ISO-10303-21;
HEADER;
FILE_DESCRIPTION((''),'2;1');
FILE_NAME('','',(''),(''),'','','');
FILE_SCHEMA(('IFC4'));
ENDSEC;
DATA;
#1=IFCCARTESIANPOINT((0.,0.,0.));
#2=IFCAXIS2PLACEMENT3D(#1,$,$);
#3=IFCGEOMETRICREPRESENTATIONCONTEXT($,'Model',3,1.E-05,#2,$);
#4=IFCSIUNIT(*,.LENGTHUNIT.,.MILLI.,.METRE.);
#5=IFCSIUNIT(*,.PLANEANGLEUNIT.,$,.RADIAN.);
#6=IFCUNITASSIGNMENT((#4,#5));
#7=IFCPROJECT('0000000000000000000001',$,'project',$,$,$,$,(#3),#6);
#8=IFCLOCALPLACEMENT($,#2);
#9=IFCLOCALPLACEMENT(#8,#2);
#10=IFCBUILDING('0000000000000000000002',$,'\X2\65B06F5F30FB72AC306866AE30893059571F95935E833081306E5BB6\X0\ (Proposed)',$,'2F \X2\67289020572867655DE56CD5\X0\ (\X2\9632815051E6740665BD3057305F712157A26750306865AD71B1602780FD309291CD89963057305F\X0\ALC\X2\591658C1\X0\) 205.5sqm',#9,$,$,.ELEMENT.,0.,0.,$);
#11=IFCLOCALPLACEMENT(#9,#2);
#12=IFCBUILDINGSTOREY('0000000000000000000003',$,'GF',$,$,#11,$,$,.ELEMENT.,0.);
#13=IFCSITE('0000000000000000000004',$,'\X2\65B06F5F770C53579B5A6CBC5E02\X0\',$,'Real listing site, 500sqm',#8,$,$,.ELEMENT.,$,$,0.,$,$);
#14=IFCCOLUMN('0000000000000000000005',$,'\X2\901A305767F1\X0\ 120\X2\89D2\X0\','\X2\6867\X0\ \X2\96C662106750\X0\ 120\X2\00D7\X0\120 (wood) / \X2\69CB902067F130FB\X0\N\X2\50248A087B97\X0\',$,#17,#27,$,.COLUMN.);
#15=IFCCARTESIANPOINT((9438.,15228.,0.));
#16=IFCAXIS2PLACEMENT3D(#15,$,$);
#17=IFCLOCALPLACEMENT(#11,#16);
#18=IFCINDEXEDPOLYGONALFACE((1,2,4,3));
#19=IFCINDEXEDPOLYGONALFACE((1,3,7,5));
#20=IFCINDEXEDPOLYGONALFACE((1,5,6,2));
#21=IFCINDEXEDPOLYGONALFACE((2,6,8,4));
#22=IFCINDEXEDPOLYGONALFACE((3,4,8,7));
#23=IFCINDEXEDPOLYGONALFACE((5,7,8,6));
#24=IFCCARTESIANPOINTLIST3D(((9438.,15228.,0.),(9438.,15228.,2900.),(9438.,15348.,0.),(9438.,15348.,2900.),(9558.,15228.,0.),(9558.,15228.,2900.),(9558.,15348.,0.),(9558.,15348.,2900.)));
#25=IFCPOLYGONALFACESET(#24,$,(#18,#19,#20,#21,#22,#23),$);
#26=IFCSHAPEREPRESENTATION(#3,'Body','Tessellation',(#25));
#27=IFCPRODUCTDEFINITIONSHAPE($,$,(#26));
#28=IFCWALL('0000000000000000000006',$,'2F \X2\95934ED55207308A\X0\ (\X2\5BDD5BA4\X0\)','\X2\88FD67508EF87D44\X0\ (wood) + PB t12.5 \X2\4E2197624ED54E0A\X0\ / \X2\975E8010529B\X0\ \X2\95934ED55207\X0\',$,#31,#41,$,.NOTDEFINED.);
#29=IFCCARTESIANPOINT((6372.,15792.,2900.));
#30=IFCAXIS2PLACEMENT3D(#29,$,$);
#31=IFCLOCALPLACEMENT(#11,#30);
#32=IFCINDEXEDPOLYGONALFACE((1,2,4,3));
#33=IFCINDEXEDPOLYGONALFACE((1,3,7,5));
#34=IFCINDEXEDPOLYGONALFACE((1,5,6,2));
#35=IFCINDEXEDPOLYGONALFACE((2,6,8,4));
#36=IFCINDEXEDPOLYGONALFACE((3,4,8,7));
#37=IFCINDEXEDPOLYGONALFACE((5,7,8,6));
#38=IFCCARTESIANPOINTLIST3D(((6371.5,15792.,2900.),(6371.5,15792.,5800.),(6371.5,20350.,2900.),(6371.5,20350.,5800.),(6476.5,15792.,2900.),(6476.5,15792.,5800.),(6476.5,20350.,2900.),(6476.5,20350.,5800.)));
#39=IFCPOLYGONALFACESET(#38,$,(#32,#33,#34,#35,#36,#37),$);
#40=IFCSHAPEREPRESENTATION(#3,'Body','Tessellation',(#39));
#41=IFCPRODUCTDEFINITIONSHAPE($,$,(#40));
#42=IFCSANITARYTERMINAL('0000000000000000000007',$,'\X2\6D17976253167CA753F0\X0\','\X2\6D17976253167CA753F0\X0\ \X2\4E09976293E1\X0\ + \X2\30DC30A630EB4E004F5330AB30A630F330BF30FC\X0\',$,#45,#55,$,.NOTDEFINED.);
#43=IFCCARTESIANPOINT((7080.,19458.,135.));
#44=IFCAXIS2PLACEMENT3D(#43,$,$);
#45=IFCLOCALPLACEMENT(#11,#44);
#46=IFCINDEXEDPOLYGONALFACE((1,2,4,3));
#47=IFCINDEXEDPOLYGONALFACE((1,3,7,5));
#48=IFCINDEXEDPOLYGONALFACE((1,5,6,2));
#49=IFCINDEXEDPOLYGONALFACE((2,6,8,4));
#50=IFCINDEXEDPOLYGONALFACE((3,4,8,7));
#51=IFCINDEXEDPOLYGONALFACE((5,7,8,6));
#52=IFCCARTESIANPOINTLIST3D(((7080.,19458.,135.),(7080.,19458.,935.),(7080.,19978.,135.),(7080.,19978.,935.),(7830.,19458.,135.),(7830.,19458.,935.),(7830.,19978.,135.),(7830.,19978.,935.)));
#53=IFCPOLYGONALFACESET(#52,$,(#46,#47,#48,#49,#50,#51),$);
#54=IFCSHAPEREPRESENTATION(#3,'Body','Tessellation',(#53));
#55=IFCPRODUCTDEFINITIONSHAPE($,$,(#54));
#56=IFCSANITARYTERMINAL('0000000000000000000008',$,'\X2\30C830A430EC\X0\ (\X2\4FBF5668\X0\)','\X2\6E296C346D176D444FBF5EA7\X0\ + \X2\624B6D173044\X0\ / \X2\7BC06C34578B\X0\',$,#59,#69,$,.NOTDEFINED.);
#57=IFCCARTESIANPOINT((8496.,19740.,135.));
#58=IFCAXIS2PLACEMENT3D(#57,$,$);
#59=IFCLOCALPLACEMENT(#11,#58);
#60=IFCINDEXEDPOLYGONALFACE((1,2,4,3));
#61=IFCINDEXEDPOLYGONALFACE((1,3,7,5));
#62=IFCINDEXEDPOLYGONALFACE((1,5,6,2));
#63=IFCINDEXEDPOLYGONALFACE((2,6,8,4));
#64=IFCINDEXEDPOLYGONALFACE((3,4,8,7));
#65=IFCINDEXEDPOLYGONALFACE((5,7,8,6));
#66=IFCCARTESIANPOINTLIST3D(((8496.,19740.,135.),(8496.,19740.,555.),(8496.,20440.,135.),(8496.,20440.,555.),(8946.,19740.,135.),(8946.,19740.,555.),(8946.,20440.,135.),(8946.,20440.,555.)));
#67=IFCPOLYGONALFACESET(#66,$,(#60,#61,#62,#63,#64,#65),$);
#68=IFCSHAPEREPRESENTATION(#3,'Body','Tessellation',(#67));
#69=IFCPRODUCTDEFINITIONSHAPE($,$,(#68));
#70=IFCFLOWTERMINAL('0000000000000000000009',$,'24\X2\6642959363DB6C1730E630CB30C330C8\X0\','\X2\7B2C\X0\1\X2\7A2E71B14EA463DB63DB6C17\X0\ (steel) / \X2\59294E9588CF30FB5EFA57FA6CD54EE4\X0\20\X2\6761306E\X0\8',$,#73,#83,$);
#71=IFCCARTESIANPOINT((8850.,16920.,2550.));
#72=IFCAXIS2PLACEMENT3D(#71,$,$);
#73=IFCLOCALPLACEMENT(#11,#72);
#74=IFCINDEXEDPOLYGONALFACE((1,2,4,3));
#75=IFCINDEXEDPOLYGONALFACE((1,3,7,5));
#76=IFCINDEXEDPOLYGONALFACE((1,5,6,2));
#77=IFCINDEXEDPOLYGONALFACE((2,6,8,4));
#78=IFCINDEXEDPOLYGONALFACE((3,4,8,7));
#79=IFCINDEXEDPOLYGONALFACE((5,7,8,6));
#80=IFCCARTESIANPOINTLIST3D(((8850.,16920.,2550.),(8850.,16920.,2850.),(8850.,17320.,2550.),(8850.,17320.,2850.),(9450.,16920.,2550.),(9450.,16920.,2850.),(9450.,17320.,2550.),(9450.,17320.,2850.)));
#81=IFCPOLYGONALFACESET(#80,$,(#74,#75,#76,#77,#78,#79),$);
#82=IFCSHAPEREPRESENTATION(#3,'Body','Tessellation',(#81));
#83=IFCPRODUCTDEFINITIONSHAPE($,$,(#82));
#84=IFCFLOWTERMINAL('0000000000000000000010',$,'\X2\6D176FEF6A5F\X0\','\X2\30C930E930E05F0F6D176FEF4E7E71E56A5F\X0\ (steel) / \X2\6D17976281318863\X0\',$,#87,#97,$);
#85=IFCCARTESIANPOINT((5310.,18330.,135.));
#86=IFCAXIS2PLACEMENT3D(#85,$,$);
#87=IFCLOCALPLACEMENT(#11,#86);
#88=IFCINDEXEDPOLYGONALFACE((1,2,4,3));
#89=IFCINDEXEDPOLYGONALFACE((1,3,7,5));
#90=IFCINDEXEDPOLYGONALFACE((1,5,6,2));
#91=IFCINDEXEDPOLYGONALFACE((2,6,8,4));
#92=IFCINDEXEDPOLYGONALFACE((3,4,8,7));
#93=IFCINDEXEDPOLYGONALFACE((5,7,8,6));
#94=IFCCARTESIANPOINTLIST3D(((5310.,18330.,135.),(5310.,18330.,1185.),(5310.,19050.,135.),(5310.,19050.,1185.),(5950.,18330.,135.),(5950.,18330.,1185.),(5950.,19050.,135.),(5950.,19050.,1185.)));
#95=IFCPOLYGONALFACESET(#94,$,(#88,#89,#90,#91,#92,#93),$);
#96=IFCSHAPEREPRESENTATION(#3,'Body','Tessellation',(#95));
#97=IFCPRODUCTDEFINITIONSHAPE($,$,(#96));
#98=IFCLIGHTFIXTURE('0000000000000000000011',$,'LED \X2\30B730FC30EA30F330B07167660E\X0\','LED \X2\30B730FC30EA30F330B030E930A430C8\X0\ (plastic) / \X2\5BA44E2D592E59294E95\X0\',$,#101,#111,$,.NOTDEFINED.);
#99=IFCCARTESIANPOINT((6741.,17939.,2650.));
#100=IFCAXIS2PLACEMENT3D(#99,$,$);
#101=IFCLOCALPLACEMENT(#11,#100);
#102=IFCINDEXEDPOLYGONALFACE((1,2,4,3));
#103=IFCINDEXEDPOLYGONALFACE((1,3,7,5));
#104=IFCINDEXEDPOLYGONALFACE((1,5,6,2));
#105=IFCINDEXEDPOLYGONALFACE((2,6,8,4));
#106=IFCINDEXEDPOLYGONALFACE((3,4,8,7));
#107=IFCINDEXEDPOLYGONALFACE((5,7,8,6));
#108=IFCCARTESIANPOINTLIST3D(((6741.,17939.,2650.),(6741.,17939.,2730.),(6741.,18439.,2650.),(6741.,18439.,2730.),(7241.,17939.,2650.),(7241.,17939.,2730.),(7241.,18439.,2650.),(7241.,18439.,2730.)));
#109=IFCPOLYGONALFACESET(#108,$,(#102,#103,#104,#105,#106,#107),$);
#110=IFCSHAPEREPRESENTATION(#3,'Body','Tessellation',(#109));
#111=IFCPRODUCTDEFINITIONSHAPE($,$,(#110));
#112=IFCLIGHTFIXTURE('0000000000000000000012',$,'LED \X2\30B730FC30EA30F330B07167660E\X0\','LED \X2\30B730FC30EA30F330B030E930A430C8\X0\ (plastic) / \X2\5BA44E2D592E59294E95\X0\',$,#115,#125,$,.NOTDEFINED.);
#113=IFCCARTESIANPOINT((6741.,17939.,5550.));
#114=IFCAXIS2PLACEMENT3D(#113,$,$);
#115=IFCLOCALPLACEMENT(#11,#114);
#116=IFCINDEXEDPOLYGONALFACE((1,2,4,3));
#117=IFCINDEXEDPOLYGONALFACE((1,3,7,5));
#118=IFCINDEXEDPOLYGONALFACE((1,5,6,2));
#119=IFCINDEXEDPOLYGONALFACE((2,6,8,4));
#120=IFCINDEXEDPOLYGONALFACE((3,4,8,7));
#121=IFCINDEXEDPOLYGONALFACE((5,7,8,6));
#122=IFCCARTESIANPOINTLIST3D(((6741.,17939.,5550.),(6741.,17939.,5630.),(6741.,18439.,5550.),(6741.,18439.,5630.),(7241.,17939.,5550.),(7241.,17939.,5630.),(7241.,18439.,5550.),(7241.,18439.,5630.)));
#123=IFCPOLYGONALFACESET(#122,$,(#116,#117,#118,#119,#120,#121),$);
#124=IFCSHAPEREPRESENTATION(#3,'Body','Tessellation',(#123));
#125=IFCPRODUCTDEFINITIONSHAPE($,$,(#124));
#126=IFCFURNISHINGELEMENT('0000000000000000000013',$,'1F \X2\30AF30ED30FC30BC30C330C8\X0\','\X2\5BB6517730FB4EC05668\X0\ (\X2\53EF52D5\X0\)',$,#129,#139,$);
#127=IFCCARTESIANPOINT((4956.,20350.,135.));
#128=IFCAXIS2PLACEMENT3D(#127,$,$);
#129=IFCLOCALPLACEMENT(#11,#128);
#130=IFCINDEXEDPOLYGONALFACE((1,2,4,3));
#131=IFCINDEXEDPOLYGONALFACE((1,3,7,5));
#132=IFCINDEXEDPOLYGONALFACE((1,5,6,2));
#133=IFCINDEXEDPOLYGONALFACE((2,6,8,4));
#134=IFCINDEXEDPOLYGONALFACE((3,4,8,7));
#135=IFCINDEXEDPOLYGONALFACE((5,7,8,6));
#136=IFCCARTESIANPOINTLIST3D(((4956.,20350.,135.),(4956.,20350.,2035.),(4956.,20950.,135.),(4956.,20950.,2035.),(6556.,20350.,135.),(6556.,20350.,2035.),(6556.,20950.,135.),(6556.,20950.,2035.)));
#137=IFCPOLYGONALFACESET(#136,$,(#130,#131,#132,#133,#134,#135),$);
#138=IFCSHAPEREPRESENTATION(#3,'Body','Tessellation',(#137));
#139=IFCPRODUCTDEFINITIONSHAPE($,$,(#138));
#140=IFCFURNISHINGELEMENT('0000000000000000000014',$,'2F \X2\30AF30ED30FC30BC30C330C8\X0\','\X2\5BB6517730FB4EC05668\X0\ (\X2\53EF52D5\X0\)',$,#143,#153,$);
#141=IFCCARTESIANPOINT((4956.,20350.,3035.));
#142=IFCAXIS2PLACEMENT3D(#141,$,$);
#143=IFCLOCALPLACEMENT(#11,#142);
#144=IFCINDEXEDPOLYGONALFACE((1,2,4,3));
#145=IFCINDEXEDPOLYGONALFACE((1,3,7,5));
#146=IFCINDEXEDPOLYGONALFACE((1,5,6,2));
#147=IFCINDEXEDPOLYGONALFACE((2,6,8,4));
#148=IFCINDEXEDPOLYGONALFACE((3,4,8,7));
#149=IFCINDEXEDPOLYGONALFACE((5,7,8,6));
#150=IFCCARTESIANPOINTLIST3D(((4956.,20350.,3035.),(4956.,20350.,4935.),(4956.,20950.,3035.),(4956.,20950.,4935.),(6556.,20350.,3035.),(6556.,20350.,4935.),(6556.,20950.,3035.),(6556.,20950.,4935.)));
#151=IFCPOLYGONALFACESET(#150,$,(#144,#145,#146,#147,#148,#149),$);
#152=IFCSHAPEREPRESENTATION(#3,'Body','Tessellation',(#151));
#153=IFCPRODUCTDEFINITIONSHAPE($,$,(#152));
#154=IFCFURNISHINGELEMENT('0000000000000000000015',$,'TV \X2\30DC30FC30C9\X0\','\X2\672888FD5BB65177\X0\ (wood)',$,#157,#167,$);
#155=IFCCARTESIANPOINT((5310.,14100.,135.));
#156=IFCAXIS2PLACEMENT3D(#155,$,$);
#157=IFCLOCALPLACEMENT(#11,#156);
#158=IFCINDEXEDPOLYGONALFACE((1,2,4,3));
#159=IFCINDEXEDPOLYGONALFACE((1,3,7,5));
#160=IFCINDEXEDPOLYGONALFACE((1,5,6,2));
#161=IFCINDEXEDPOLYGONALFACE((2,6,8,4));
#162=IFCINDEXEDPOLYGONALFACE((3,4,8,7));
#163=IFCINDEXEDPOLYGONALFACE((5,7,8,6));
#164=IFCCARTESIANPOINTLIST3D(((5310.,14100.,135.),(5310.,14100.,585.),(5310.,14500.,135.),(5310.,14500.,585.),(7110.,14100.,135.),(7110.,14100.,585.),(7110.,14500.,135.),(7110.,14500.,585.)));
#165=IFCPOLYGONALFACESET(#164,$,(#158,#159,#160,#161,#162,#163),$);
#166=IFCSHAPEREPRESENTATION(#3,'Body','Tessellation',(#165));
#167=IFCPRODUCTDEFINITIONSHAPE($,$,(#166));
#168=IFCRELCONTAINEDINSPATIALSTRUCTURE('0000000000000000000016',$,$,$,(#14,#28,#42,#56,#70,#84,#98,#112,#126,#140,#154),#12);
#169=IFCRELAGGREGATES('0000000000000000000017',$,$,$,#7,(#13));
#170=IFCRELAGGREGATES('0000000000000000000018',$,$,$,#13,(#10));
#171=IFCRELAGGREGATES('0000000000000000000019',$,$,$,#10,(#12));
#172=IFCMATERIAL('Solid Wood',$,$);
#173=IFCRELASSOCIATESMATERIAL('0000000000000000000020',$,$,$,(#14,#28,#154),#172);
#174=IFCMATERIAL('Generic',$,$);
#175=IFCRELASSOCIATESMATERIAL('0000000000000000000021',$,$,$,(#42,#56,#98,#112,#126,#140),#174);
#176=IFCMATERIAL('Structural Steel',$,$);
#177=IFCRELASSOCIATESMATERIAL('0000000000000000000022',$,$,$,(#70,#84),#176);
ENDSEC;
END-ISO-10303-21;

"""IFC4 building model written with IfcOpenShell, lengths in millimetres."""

from ifc_helpers import new_model, si_unit, frame, frame_2d, origin, place, context, project, spatial, rectangle, extrude, material, element, save


model = new_model("IFC4")

# Units and contexts
model_context = context("Model", 3, precision=1e-05, world=origin())
ifc_project = project(units=[si_unit("LENGTHUNIT", "METRE", prefix="MILLI"), si_unit("PLANEANGLEUNIT", "RADIAN")], contexts=[model_context])

# Site, building, storey
site_placement = place(None, origin())
site = spatial("IfcSite", under=ifc_project, at=site_placement, Name="新潟県南魚沼市", ObjectType="Real listing site, 500sqm", CompositionType="ELEMENT", RefElevation=0.0)
building_placement = place(site_placement, origin())
building = spatial("IfcBuilding", under=site, at=building_placement, Name="新潟・犬と暮らす土間広めの家 (Proposed)", ObjectType="2F 木造在来工法 (防腐処理施した無垢材と断熱性能を重視したALC外壁) 205.5sqm", CompositionType="ELEMENT", ElevationOfRefHeight=0.0, ElevationOfTerrain=0.0)
storey_placement = place(building_placement, origin())
storey = spatial("IfcBuildingStorey", under=building, at=storey_placement, Name="GF", CompositionType="ELEMENT", Elevation=0.0)

# Column
ifc_material_1 = material(Name="Solid Wood")
column_1_placement = place(storey_placement, frame((9438.0, 15228.0, 0.0)))
element("IfcColumn", 1, at=column_1_placement, inside=storey, material=ifc_material_1, Name="通し柱 120角", Description="桧 集成材 120×120 (wood) / 構造柱・N値計算", PredefinedType="COLUMN", context=model_context, shape_type="SweptSolid", body=[
    extrude(rectangle(XDim=120.0, YDim=120.0, at=frame_2d((60.0, 60.0))), frame((9438.0, 15228.0, 0.0)), (0.0, 0.0, 1.0), 2900.0),
])

# Wall
wall_1_placement = place(storey_placement, frame((6372.0, 15792.0, 2900.0)))
element("IfcWall", 2, at=wall_1_placement, inside=storey, material=ifc_material_1, Name="2F 間仕切り (寝室)", Description="製材軸組 (wood) + PB t12.5 両面仕上 / 非耐力 間仕切", PredefinedType="NOTDEFINED", context=model_context, shape_type="SweptSolid", body=[
    extrude(rectangle(XDim=105.0, YDim=4558.0, at=frame_2d((52.0, 2279.0))), frame((6372.0, 15792.0, 2900.0)), (0.0, 0.0, 1.0), 2900.0),
])

# Sanitary terminals
ifc_material_2 = material(Name="Generic")
sanitary_terminal_1_placement = place(storey_placement, frame((7080.0, 19458.0, 135.0)))
element("IfcSanitaryTerminal", 3, at=sanitary_terminal_1_placement, inside=storey, material=ifc_material_2, Name="洗面化粧台", Description="洗面化粧台 三面鏡 + ボウル一体カウンター", PredefinedType="NOTDEFINED", context=model_context, shape_type="SweptSolid", body=[
    extrude(rectangle(XDim=750.0, YDim=520.0, at=frame_2d((375.0, 260.0))), frame((7080.0, 19458.0, 135.0)), (0.0, 0.0, 1.0), 800.0),
])
sanitary_terminal_2_placement = place(storey_placement, frame((8496.0, 19740.0, 135.0)))
element("IfcSanitaryTerminal", 4, at=sanitary_terminal_2_placement, inside=storey, material=ifc_material_2, Name="トイレ (便器)", Description="温水洗浄便座 + 手洗い / 節水型", PredefinedType="NOTDEFINED", context=model_context, shape_type="SweptSolid", body=[
    extrude(rectangle(XDim=450.0, YDim=700.0, at=frame_2d((225.0, 350.0))), frame((8496.0, 19740.0, 135.0)), (0.0, 0.0, 1.0), 420.0),
])

# Flow terminals
ifc_material_3 = material(Name="Structural Steel")
flow_terminal_1_placement = place(storey_placement, frame((8850.0, 16920.0, 2550.0)))
element("IfcFlowTerminal", 5, at=flow_terminal_1_placement, inside=storey, material=ifc_material_3, Name="24時間換気ユニット", Description="第1種熱交換換気 (steel) / 天井裏・建基法令20条の8", context=model_context, shape_type="SweptSolid", body=[
    extrude(rectangle(XDim=600.0, YDim=400.0, at=frame_2d((300.0, 200.0))), frame((8850.0, 16920.0, 2550.0)), (0.0, 0.0, 1.0), 300.0),
])
flow_terminal_2_placement = place(storey_placement, frame((5310.0, 18330.0, 135.0)))
element("IfcFlowTerminal", 6, at=flow_terminal_2_placement, inside=storey, material=ifc_material_3, Name="洗濯機", Description="ドラム式洗濯乾燥機 (steel) / 洗面脱衣", context=model_context, shape_type="SweptSolid", body=[
    extrude(rectangle(XDim=640.0, YDim=720.0, at=frame_2d((320.0, 360.0))), frame((5310.0, 18330.0, 135.0)), (0.0, 0.0, 1.0), 1050.0),
])

# Light fixtures
light_fixture_1_placement = place(storey_placement, frame((6741.0, 17939.0, 2650.0)))
element("IfcLightFixture", 7, at=light_fixture_1_placement, inside=storey, material=ifc_material_2, Name="LED シーリング照明", Description="LED シーリングライト (plastic) / 室中央天井", PredefinedType="NOTDEFINED", context=model_context, shape_type="SweptSolid", body=[
    extrude(rectangle(XDim=500.0, YDim=500.0, at=frame_2d((250.0, 250.0))), frame((6741.0, 17939.0, 2650.0)), (0.0, 0.0, 1.0), 80.0),
])
light_fixture_2_placement = place(storey_placement, frame((6741.0, 17939.0, 5550.0)))
element("IfcLightFixture", 8, at=light_fixture_2_placement, inside=storey, material=ifc_material_2, Name="LED シーリング照明", Description="LED シーリングライト (plastic) / 室中央天井", PredefinedType="NOTDEFINED", context=model_context, shape_type="SweptSolid", body=[
    extrude(rectangle(XDim=500.0, YDim=500.0, at=frame_2d((250.0, 250.0))), frame((6741.0, 17939.0, 5550.0)), (0.0, 0.0, 1.0), 80.0),
])

# Furnishing elements
furnishing_1_placement = place(storey_placement, frame((4956.0, 20350.0, 135.0)))
element("IfcFurnishingElement", 9, at=furnishing_1_placement, inside=storey, material=ifc_material_2, Name="1F クローゼット", Description="家具・什器 (可動)", context=model_context, shape_type="SweptSolid", body=[
    extrude(rectangle(XDim=1600.0, YDim=600.0, at=frame_2d((800.0, 300.0))), frame((4956.0, 20350.0, 135.0)), (0.0, 0.0, 1.0), 1900.0),
])
furnishing_2_placement = place(storey_placement, frame((4956.0, 20350.0, 3035.0)))
element("IfcFurnishingElement", 10, at=furnishing_2_placement, inside=storey, material=ifc_material_2, Name="2F クローゼット", Description="家具・什器 (可動)", context=model_context, shape_type="SweptSolid", body=[
    extrude(rectangle(XDim=1600.0, YDim=600.0, at=frame_2d((800.0, 300.0))), frame((4956.0, 20350.0, 3035.0)), (0.0, 0.0, 1.0), 1900.0),
])
furnishing_3_placement = place(storey_placement, frame((5310.0, 14100.0, 135.0)))
element("IfcFurnishingElement", 11, at=furnishing_3_placement, inside=storey, material=ifc_material_1, Name="TV ボード", Description="木製家具 (wood)", context=model_context, shape_type="SweptSolid", body=[
    extrude(rectangle(XDim=1800.0, YDim=400.0, at=frame_2d((900.0, 200.0))), frame((5310.0, 14100.0, 135.0)), (0.0, 0.0, 1.0), 450.0),
])

save(model, "model.ifc")
